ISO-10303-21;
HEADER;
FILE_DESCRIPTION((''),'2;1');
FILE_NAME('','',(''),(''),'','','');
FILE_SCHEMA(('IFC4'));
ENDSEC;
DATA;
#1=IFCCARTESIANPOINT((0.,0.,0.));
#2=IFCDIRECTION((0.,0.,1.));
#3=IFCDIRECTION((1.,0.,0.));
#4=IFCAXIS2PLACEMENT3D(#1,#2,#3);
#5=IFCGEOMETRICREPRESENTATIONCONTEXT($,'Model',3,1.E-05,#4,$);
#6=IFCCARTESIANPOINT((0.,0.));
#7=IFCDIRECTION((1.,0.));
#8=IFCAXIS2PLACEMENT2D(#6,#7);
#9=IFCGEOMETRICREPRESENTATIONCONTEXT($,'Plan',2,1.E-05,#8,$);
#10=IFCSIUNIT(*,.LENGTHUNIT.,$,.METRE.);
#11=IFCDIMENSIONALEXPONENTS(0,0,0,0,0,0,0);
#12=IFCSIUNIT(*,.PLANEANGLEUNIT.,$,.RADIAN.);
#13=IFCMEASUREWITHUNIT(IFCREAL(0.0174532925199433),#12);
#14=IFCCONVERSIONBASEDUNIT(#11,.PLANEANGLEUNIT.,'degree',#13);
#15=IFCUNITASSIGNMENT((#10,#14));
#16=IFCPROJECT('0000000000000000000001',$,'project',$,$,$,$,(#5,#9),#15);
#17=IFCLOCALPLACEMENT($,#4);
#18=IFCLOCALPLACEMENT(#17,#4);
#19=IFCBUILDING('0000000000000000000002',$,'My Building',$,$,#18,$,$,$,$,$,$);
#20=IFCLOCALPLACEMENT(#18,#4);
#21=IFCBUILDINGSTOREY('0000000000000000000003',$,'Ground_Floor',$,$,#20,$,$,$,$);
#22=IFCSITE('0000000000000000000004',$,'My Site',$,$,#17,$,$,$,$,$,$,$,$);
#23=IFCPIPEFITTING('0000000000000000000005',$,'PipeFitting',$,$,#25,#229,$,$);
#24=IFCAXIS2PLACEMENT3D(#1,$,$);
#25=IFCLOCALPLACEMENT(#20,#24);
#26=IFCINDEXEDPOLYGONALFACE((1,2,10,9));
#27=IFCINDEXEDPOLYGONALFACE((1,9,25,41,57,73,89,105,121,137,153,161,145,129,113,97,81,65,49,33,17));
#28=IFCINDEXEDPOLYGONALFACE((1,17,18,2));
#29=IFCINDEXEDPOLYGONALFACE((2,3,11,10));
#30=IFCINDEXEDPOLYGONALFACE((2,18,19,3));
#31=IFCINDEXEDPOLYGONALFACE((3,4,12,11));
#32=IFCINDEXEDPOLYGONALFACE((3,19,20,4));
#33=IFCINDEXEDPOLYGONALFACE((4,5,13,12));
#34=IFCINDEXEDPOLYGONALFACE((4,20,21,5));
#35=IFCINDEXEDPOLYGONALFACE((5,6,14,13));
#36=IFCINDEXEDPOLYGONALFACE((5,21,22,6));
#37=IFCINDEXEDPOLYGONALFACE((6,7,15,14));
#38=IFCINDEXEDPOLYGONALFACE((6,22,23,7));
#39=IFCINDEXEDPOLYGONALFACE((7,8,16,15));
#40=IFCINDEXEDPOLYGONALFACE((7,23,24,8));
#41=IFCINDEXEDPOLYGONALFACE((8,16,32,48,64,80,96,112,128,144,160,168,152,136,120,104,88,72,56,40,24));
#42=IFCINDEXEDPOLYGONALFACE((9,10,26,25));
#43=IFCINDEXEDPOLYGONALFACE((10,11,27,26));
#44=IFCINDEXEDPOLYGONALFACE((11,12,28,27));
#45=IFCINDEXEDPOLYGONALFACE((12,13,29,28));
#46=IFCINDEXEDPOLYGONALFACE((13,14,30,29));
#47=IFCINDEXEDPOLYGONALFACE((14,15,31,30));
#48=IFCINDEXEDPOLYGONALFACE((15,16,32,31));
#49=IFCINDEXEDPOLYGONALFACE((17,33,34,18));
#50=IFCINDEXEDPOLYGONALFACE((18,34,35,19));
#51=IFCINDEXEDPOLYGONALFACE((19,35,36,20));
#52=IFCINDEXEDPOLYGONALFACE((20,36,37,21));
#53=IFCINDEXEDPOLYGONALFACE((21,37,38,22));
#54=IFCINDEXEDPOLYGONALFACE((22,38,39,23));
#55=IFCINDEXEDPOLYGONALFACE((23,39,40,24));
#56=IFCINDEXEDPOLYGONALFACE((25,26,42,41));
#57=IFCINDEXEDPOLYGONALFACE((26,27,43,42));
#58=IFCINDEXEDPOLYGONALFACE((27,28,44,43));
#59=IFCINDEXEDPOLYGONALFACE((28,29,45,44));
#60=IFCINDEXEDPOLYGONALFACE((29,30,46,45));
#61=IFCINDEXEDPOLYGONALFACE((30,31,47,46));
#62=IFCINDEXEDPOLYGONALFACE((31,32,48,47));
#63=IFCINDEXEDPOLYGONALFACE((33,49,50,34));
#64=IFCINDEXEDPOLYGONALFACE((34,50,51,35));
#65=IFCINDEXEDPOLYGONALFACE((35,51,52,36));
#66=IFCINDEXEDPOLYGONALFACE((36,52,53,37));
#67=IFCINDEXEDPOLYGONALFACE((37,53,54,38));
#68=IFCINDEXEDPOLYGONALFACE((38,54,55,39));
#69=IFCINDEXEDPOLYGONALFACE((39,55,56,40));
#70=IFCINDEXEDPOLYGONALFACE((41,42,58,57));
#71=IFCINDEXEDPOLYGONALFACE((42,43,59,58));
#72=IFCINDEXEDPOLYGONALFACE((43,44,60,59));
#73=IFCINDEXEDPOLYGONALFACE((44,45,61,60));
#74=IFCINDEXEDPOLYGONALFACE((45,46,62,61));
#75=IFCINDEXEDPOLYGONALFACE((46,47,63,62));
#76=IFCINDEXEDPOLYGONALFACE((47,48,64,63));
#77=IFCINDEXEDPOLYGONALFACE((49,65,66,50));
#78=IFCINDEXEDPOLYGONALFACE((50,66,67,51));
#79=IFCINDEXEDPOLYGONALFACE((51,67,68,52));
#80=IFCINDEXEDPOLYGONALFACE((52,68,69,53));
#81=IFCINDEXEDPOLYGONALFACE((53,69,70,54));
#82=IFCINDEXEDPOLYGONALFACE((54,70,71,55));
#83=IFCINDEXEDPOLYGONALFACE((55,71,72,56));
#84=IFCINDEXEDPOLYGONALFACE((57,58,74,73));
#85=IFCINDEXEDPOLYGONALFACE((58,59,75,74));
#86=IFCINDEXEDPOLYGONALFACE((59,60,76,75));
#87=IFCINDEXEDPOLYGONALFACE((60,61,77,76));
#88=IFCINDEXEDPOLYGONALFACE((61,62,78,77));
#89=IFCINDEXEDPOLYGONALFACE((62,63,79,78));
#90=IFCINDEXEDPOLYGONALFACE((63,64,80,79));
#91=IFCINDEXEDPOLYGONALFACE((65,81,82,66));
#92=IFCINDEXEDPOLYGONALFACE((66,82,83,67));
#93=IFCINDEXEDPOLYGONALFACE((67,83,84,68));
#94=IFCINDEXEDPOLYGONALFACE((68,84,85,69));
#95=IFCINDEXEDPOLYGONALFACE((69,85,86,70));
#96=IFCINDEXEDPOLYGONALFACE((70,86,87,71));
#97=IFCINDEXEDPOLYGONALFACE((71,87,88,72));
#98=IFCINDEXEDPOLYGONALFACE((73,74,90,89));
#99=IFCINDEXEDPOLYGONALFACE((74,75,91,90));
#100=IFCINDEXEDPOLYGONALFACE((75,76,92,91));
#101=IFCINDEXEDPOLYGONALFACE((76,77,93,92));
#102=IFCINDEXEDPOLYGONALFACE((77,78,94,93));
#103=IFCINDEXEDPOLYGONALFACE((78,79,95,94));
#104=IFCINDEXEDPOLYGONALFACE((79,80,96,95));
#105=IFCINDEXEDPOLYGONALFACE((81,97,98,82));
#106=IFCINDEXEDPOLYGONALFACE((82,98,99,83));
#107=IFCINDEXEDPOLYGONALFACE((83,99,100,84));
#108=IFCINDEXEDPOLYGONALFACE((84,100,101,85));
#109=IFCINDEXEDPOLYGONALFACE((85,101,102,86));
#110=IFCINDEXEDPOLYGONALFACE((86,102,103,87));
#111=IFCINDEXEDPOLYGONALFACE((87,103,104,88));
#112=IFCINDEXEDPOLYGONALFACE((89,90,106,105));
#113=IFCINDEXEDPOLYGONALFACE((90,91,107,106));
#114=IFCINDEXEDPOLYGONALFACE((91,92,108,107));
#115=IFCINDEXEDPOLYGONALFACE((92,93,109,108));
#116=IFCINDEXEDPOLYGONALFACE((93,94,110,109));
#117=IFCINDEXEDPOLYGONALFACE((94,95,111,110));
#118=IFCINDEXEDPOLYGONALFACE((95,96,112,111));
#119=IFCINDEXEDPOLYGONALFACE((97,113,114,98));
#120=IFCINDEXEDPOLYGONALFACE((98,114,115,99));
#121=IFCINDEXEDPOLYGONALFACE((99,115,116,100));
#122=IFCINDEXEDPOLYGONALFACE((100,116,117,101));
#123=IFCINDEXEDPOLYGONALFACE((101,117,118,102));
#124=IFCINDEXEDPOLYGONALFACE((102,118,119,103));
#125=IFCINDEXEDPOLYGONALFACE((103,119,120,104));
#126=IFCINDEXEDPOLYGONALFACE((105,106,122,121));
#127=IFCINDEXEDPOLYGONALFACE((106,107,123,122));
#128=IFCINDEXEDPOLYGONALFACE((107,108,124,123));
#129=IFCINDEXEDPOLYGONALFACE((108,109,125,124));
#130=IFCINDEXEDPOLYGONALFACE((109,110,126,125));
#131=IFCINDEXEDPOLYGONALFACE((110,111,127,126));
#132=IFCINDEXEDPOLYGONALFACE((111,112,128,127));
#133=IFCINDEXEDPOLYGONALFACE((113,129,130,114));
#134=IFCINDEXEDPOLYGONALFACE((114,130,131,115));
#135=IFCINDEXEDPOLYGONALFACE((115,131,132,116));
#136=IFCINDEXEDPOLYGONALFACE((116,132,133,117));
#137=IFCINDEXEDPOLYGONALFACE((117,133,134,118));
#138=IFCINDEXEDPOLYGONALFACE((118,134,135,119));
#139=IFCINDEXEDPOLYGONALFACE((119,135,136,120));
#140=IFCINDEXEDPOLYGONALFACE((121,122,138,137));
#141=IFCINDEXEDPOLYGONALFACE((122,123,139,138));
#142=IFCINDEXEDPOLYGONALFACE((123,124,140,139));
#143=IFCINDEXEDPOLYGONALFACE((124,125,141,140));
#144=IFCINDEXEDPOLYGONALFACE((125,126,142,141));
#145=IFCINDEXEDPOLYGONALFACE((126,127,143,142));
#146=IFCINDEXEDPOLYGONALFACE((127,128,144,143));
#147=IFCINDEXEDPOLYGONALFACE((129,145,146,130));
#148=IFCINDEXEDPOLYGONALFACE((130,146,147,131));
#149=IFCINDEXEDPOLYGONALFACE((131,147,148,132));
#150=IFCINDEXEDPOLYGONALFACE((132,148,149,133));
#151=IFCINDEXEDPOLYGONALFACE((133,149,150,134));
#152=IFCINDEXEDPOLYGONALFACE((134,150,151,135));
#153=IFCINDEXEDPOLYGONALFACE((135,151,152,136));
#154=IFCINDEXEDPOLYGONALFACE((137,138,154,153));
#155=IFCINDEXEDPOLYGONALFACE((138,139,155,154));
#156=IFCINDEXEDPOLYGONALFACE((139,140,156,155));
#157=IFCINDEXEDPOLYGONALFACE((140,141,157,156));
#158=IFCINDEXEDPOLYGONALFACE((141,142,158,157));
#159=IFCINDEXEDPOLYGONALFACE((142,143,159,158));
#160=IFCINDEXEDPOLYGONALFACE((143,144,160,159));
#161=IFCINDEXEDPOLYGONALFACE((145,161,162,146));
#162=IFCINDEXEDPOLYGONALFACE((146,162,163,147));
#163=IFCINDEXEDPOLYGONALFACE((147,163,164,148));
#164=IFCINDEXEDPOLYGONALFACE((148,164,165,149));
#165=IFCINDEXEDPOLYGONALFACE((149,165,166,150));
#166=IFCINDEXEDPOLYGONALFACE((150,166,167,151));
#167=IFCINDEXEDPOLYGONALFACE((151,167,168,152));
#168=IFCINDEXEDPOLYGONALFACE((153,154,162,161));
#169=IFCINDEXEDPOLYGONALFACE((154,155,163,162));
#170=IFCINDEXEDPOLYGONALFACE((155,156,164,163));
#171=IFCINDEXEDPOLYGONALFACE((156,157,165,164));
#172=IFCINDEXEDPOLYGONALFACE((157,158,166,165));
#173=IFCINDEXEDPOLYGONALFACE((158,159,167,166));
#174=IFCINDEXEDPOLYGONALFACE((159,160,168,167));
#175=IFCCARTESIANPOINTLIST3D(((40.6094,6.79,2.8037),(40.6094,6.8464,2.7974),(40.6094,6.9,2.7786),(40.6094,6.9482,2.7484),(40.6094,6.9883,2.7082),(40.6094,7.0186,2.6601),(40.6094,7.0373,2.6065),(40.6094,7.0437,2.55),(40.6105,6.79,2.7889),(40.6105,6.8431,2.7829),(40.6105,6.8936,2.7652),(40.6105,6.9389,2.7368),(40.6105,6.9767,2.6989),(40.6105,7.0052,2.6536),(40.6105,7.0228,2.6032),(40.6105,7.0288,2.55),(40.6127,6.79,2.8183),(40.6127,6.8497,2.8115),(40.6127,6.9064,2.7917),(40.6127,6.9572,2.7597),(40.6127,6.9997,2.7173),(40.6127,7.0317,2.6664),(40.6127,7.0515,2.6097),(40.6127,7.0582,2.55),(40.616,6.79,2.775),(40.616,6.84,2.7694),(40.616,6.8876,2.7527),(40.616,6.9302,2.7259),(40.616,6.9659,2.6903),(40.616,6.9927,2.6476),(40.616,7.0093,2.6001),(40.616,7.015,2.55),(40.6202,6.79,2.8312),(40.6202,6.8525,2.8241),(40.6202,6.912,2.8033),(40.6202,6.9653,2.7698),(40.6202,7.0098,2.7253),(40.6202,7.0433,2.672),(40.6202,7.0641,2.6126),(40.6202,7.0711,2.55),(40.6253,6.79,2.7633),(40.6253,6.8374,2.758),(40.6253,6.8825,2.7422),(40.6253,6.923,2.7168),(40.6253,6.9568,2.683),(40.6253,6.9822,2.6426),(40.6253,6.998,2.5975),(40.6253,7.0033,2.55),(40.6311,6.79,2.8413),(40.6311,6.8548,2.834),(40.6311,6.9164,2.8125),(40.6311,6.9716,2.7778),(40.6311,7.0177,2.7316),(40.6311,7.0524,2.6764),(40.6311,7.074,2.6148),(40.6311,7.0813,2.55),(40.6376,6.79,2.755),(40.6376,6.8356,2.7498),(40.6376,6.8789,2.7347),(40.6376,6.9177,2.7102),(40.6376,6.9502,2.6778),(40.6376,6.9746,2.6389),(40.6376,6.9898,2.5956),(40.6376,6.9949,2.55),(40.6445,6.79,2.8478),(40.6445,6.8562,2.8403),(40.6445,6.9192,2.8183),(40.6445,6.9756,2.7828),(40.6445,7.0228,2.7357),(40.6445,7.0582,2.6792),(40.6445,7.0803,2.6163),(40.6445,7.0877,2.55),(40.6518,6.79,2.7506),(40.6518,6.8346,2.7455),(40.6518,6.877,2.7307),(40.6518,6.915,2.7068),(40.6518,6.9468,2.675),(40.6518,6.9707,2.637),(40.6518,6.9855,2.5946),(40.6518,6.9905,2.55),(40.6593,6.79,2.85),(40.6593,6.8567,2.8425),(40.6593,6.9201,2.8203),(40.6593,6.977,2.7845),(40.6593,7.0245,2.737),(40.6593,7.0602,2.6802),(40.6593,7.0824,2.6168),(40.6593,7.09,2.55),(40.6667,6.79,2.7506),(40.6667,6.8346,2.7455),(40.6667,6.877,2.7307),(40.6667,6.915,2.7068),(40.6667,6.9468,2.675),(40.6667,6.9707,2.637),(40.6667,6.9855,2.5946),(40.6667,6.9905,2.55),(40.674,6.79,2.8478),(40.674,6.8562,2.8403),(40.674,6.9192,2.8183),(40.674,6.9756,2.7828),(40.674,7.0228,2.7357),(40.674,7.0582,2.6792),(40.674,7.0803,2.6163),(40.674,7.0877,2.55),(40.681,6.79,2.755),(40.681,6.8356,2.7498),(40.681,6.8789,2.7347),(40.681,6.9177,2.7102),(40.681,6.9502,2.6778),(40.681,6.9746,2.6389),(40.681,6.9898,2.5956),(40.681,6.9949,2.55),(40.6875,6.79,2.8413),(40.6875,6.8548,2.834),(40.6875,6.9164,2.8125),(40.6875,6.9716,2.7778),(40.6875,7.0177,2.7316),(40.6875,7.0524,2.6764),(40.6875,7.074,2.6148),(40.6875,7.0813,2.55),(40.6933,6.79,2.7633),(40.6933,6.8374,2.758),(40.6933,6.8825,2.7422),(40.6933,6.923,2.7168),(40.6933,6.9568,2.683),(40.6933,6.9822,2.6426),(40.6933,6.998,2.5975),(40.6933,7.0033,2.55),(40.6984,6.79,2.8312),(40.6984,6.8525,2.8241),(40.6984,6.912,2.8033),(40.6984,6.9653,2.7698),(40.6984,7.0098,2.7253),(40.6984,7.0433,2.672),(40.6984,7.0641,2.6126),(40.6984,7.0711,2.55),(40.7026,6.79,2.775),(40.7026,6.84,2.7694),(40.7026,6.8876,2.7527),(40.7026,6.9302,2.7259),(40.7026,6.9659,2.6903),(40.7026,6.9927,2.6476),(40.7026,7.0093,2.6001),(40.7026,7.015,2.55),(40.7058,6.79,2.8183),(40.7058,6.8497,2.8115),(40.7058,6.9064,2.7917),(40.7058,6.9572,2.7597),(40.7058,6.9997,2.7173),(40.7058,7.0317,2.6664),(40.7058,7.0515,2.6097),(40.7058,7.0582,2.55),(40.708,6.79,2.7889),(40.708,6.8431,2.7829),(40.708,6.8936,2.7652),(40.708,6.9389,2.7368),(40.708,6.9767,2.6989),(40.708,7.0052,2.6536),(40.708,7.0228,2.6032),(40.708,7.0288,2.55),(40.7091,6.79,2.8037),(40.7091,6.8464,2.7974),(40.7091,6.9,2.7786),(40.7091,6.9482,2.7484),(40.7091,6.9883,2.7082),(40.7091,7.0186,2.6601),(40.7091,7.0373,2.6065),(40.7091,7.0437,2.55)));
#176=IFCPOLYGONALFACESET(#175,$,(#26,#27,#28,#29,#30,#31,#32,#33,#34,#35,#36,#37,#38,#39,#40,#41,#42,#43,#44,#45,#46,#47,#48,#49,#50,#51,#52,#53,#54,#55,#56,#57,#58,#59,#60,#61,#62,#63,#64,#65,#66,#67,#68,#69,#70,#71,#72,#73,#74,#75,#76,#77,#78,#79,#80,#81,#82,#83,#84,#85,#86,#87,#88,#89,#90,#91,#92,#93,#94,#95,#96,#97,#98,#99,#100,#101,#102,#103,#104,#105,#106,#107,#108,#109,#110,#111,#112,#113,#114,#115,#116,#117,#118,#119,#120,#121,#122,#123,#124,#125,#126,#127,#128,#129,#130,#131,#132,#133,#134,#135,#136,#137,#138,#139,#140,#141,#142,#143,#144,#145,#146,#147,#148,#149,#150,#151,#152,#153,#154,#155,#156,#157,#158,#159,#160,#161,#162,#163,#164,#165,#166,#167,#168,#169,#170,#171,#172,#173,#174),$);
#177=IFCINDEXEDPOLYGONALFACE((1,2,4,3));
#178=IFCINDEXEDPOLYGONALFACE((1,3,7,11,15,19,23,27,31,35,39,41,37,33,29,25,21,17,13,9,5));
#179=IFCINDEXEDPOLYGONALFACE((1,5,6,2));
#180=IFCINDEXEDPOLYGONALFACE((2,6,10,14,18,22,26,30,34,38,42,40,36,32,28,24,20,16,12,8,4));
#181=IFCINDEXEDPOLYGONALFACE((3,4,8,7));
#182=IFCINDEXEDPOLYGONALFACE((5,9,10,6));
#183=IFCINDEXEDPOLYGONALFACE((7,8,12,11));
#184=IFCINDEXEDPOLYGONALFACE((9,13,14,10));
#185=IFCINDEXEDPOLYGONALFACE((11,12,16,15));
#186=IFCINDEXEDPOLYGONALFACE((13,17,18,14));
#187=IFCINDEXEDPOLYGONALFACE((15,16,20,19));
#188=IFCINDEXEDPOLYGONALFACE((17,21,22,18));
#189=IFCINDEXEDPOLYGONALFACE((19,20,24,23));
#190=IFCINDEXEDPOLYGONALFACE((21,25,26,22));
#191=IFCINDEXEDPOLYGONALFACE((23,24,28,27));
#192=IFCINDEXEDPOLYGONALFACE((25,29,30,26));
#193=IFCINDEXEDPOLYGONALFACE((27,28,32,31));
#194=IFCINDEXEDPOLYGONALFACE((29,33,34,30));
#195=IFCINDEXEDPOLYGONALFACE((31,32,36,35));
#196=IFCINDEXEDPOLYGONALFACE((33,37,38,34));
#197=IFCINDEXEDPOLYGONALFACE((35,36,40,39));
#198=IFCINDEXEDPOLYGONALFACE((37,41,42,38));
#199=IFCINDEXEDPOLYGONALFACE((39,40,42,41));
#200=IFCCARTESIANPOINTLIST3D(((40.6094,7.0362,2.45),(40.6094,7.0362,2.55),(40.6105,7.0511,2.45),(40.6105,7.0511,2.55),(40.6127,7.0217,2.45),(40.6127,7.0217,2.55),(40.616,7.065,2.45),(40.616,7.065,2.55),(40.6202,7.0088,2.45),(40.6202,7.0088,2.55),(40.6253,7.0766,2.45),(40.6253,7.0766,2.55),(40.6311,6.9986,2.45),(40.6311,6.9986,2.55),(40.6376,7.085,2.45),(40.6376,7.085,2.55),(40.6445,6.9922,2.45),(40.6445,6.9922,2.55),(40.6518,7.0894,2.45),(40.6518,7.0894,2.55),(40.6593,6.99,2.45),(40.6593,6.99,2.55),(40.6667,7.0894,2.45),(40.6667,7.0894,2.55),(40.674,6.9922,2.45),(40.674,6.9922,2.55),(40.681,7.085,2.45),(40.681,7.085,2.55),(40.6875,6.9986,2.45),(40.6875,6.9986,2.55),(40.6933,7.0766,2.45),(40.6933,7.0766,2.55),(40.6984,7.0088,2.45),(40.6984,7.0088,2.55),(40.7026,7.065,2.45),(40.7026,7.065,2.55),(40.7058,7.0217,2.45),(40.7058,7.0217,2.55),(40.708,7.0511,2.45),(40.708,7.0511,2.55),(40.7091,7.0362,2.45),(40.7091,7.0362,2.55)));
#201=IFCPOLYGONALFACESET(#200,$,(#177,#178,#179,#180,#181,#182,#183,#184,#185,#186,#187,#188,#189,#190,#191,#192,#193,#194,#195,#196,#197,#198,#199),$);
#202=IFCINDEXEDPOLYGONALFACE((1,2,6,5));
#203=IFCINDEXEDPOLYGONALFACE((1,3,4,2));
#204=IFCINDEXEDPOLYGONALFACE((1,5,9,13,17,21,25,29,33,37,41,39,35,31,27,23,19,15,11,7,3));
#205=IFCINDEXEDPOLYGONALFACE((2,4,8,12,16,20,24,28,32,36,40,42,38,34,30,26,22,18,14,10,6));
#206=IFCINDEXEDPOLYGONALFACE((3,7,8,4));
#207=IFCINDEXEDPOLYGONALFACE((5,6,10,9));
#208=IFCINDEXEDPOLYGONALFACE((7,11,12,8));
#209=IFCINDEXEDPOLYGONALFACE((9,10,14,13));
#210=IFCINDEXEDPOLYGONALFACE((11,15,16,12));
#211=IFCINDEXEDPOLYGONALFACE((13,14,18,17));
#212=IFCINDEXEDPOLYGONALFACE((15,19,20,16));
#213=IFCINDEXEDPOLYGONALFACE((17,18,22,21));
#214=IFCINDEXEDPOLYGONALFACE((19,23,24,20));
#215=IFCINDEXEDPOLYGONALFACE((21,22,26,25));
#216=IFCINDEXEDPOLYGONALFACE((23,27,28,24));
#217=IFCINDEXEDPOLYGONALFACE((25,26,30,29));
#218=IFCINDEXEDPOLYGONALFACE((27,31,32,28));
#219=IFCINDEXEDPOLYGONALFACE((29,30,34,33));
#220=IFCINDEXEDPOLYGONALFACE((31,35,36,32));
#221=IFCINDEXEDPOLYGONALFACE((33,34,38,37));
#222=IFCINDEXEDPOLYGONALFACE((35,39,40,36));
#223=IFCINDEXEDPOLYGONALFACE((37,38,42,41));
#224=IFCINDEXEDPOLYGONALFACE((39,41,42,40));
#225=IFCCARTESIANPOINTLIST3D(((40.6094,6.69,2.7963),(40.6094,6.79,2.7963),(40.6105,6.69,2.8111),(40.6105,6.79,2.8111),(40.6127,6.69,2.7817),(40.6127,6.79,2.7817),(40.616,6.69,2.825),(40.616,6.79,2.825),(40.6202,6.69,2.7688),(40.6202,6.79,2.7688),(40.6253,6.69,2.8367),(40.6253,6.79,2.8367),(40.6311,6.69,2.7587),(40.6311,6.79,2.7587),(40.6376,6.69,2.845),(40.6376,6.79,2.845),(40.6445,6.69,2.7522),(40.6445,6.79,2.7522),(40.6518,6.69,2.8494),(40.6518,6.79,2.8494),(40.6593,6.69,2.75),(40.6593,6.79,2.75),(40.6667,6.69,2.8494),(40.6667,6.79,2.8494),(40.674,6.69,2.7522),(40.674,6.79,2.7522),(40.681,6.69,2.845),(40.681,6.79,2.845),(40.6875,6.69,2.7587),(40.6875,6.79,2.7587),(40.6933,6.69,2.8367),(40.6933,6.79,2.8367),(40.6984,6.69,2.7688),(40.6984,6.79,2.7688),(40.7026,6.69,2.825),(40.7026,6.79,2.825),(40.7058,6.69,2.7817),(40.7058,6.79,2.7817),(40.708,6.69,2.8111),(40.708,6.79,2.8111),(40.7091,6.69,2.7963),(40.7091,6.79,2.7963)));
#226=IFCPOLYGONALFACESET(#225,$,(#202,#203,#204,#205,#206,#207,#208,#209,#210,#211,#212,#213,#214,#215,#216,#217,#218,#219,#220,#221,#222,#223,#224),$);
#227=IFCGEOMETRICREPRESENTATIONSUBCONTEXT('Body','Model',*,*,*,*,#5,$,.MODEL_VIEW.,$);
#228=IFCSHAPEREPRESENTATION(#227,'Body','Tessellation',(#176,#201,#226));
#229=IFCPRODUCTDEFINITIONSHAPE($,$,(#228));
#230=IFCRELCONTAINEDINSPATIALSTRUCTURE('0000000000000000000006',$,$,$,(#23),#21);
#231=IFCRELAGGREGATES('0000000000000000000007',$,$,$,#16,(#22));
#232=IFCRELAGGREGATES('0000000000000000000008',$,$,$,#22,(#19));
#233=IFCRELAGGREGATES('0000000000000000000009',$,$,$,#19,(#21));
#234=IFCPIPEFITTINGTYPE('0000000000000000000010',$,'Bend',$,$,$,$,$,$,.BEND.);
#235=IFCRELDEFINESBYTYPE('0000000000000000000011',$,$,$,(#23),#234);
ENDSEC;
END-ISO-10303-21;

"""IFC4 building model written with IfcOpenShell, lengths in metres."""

from ifc_helpers import new_model, entity, si_unit, converted_unit, frame, origin_with_axes, origin_2d_with_axis, place, context, subcontext, project, spatial, circle, extrude, source, transform, mapped, type_object, type_shapes, element, save


model = new_model("IFC4")

# Units and contexts
model_context = context("Model", 3, precision=1e-05, world=origin_with_axes())
plan_context = context("Plan", 2, precision=1e-05, world=origin_2d_with_axis())
body_context = subcontext(model_context, "Body", "Model", "MODEL_VIEW")
ifc_project = project(units=[si_unit("LENGTHUNIT", "METRE"), converted_unit("PLANEANGLEUNIT", "degree", entity("IfcReal", 0.0174532925199433), si_unit("PLANEANGLEUNIT", "RADIAN"), dimensions=[0, 0, 0, 0, 0, 0, 0])], contexts=[model_context, plan_context])

# Site, building, storey
site_placement = place(None, origin_with_axes())
site = spatial("IfcSite", under=ifc_project, at=site_placement, Name="My Site")
building_placement = place(site_placement, origin_with_axes())
building = spatial("IfcBuilding", under=site, at=building_placement, Name="My Building")
storey_placement = place(building_placement, origin_with_axes())
storey = spatial("IfcBuildingStorey", under=building, at=storey_placement, Name="Ground_Floor")

# Pipe fitting
pipe_fitting_type = type_object("IfcPipeFittingType", Name="Bend", PredefinedType="BEND")
shared_shape = source(origin_with_axes(), body_context, "Body", "SolidModel", [
    entity("IfcSweptDiskSolid", entity("IfcIndexedPolyCurve", entity("IfcCartesianPointList3D", [[0.0, 0.0, -0.1], [0.0732, 0.0, -0.2768], [0.25, 0.0, -0.35]]), [entity("IfcArcIndex", [1, 2, 3])]), 0.05),
    extrude(circle(Radius=0.05), origin_with_axes(), (0.0, 0.0, -1.0), 0.1),
    extrude(circle(Radius=0.05), frame((0.25, 0.0, -0.35), z_axis=(1.0, 0.0, 0.0), x_axis=(0.0, 0.0, 1.0)), (0.0, 0.0, 1.0), 0.1),
])
type_shapes(pipe_fitting_type, [shared_shape])
for number, where, z_axis, x_axis, name in (
    (1, (40.6593, 7.04, 2.45), (0.000001, 0.0, -1.0), (0.0, -1.0, 0.0), "PipeFitting"),
):
    element("IfcPipeFitting", number, at=place(storey_placement, frame(where, z_axis=z_axis, x_axis=x_axis)), inside=storey, type_object=pipe_fitting_type, Name=name, context=body_context, shape_type="MappedRepresentation", body=[
        mapped(shared_shape, transform((0.0, 0.0, 0.0), x_axis=(1.0, 0.0, 0.0), y_axis=(0.0, 1.0, 0.0), z_axis=(0.0, 0.0, 1.0), scale=1.0)),
    ])

save(model, "model.ifc")
